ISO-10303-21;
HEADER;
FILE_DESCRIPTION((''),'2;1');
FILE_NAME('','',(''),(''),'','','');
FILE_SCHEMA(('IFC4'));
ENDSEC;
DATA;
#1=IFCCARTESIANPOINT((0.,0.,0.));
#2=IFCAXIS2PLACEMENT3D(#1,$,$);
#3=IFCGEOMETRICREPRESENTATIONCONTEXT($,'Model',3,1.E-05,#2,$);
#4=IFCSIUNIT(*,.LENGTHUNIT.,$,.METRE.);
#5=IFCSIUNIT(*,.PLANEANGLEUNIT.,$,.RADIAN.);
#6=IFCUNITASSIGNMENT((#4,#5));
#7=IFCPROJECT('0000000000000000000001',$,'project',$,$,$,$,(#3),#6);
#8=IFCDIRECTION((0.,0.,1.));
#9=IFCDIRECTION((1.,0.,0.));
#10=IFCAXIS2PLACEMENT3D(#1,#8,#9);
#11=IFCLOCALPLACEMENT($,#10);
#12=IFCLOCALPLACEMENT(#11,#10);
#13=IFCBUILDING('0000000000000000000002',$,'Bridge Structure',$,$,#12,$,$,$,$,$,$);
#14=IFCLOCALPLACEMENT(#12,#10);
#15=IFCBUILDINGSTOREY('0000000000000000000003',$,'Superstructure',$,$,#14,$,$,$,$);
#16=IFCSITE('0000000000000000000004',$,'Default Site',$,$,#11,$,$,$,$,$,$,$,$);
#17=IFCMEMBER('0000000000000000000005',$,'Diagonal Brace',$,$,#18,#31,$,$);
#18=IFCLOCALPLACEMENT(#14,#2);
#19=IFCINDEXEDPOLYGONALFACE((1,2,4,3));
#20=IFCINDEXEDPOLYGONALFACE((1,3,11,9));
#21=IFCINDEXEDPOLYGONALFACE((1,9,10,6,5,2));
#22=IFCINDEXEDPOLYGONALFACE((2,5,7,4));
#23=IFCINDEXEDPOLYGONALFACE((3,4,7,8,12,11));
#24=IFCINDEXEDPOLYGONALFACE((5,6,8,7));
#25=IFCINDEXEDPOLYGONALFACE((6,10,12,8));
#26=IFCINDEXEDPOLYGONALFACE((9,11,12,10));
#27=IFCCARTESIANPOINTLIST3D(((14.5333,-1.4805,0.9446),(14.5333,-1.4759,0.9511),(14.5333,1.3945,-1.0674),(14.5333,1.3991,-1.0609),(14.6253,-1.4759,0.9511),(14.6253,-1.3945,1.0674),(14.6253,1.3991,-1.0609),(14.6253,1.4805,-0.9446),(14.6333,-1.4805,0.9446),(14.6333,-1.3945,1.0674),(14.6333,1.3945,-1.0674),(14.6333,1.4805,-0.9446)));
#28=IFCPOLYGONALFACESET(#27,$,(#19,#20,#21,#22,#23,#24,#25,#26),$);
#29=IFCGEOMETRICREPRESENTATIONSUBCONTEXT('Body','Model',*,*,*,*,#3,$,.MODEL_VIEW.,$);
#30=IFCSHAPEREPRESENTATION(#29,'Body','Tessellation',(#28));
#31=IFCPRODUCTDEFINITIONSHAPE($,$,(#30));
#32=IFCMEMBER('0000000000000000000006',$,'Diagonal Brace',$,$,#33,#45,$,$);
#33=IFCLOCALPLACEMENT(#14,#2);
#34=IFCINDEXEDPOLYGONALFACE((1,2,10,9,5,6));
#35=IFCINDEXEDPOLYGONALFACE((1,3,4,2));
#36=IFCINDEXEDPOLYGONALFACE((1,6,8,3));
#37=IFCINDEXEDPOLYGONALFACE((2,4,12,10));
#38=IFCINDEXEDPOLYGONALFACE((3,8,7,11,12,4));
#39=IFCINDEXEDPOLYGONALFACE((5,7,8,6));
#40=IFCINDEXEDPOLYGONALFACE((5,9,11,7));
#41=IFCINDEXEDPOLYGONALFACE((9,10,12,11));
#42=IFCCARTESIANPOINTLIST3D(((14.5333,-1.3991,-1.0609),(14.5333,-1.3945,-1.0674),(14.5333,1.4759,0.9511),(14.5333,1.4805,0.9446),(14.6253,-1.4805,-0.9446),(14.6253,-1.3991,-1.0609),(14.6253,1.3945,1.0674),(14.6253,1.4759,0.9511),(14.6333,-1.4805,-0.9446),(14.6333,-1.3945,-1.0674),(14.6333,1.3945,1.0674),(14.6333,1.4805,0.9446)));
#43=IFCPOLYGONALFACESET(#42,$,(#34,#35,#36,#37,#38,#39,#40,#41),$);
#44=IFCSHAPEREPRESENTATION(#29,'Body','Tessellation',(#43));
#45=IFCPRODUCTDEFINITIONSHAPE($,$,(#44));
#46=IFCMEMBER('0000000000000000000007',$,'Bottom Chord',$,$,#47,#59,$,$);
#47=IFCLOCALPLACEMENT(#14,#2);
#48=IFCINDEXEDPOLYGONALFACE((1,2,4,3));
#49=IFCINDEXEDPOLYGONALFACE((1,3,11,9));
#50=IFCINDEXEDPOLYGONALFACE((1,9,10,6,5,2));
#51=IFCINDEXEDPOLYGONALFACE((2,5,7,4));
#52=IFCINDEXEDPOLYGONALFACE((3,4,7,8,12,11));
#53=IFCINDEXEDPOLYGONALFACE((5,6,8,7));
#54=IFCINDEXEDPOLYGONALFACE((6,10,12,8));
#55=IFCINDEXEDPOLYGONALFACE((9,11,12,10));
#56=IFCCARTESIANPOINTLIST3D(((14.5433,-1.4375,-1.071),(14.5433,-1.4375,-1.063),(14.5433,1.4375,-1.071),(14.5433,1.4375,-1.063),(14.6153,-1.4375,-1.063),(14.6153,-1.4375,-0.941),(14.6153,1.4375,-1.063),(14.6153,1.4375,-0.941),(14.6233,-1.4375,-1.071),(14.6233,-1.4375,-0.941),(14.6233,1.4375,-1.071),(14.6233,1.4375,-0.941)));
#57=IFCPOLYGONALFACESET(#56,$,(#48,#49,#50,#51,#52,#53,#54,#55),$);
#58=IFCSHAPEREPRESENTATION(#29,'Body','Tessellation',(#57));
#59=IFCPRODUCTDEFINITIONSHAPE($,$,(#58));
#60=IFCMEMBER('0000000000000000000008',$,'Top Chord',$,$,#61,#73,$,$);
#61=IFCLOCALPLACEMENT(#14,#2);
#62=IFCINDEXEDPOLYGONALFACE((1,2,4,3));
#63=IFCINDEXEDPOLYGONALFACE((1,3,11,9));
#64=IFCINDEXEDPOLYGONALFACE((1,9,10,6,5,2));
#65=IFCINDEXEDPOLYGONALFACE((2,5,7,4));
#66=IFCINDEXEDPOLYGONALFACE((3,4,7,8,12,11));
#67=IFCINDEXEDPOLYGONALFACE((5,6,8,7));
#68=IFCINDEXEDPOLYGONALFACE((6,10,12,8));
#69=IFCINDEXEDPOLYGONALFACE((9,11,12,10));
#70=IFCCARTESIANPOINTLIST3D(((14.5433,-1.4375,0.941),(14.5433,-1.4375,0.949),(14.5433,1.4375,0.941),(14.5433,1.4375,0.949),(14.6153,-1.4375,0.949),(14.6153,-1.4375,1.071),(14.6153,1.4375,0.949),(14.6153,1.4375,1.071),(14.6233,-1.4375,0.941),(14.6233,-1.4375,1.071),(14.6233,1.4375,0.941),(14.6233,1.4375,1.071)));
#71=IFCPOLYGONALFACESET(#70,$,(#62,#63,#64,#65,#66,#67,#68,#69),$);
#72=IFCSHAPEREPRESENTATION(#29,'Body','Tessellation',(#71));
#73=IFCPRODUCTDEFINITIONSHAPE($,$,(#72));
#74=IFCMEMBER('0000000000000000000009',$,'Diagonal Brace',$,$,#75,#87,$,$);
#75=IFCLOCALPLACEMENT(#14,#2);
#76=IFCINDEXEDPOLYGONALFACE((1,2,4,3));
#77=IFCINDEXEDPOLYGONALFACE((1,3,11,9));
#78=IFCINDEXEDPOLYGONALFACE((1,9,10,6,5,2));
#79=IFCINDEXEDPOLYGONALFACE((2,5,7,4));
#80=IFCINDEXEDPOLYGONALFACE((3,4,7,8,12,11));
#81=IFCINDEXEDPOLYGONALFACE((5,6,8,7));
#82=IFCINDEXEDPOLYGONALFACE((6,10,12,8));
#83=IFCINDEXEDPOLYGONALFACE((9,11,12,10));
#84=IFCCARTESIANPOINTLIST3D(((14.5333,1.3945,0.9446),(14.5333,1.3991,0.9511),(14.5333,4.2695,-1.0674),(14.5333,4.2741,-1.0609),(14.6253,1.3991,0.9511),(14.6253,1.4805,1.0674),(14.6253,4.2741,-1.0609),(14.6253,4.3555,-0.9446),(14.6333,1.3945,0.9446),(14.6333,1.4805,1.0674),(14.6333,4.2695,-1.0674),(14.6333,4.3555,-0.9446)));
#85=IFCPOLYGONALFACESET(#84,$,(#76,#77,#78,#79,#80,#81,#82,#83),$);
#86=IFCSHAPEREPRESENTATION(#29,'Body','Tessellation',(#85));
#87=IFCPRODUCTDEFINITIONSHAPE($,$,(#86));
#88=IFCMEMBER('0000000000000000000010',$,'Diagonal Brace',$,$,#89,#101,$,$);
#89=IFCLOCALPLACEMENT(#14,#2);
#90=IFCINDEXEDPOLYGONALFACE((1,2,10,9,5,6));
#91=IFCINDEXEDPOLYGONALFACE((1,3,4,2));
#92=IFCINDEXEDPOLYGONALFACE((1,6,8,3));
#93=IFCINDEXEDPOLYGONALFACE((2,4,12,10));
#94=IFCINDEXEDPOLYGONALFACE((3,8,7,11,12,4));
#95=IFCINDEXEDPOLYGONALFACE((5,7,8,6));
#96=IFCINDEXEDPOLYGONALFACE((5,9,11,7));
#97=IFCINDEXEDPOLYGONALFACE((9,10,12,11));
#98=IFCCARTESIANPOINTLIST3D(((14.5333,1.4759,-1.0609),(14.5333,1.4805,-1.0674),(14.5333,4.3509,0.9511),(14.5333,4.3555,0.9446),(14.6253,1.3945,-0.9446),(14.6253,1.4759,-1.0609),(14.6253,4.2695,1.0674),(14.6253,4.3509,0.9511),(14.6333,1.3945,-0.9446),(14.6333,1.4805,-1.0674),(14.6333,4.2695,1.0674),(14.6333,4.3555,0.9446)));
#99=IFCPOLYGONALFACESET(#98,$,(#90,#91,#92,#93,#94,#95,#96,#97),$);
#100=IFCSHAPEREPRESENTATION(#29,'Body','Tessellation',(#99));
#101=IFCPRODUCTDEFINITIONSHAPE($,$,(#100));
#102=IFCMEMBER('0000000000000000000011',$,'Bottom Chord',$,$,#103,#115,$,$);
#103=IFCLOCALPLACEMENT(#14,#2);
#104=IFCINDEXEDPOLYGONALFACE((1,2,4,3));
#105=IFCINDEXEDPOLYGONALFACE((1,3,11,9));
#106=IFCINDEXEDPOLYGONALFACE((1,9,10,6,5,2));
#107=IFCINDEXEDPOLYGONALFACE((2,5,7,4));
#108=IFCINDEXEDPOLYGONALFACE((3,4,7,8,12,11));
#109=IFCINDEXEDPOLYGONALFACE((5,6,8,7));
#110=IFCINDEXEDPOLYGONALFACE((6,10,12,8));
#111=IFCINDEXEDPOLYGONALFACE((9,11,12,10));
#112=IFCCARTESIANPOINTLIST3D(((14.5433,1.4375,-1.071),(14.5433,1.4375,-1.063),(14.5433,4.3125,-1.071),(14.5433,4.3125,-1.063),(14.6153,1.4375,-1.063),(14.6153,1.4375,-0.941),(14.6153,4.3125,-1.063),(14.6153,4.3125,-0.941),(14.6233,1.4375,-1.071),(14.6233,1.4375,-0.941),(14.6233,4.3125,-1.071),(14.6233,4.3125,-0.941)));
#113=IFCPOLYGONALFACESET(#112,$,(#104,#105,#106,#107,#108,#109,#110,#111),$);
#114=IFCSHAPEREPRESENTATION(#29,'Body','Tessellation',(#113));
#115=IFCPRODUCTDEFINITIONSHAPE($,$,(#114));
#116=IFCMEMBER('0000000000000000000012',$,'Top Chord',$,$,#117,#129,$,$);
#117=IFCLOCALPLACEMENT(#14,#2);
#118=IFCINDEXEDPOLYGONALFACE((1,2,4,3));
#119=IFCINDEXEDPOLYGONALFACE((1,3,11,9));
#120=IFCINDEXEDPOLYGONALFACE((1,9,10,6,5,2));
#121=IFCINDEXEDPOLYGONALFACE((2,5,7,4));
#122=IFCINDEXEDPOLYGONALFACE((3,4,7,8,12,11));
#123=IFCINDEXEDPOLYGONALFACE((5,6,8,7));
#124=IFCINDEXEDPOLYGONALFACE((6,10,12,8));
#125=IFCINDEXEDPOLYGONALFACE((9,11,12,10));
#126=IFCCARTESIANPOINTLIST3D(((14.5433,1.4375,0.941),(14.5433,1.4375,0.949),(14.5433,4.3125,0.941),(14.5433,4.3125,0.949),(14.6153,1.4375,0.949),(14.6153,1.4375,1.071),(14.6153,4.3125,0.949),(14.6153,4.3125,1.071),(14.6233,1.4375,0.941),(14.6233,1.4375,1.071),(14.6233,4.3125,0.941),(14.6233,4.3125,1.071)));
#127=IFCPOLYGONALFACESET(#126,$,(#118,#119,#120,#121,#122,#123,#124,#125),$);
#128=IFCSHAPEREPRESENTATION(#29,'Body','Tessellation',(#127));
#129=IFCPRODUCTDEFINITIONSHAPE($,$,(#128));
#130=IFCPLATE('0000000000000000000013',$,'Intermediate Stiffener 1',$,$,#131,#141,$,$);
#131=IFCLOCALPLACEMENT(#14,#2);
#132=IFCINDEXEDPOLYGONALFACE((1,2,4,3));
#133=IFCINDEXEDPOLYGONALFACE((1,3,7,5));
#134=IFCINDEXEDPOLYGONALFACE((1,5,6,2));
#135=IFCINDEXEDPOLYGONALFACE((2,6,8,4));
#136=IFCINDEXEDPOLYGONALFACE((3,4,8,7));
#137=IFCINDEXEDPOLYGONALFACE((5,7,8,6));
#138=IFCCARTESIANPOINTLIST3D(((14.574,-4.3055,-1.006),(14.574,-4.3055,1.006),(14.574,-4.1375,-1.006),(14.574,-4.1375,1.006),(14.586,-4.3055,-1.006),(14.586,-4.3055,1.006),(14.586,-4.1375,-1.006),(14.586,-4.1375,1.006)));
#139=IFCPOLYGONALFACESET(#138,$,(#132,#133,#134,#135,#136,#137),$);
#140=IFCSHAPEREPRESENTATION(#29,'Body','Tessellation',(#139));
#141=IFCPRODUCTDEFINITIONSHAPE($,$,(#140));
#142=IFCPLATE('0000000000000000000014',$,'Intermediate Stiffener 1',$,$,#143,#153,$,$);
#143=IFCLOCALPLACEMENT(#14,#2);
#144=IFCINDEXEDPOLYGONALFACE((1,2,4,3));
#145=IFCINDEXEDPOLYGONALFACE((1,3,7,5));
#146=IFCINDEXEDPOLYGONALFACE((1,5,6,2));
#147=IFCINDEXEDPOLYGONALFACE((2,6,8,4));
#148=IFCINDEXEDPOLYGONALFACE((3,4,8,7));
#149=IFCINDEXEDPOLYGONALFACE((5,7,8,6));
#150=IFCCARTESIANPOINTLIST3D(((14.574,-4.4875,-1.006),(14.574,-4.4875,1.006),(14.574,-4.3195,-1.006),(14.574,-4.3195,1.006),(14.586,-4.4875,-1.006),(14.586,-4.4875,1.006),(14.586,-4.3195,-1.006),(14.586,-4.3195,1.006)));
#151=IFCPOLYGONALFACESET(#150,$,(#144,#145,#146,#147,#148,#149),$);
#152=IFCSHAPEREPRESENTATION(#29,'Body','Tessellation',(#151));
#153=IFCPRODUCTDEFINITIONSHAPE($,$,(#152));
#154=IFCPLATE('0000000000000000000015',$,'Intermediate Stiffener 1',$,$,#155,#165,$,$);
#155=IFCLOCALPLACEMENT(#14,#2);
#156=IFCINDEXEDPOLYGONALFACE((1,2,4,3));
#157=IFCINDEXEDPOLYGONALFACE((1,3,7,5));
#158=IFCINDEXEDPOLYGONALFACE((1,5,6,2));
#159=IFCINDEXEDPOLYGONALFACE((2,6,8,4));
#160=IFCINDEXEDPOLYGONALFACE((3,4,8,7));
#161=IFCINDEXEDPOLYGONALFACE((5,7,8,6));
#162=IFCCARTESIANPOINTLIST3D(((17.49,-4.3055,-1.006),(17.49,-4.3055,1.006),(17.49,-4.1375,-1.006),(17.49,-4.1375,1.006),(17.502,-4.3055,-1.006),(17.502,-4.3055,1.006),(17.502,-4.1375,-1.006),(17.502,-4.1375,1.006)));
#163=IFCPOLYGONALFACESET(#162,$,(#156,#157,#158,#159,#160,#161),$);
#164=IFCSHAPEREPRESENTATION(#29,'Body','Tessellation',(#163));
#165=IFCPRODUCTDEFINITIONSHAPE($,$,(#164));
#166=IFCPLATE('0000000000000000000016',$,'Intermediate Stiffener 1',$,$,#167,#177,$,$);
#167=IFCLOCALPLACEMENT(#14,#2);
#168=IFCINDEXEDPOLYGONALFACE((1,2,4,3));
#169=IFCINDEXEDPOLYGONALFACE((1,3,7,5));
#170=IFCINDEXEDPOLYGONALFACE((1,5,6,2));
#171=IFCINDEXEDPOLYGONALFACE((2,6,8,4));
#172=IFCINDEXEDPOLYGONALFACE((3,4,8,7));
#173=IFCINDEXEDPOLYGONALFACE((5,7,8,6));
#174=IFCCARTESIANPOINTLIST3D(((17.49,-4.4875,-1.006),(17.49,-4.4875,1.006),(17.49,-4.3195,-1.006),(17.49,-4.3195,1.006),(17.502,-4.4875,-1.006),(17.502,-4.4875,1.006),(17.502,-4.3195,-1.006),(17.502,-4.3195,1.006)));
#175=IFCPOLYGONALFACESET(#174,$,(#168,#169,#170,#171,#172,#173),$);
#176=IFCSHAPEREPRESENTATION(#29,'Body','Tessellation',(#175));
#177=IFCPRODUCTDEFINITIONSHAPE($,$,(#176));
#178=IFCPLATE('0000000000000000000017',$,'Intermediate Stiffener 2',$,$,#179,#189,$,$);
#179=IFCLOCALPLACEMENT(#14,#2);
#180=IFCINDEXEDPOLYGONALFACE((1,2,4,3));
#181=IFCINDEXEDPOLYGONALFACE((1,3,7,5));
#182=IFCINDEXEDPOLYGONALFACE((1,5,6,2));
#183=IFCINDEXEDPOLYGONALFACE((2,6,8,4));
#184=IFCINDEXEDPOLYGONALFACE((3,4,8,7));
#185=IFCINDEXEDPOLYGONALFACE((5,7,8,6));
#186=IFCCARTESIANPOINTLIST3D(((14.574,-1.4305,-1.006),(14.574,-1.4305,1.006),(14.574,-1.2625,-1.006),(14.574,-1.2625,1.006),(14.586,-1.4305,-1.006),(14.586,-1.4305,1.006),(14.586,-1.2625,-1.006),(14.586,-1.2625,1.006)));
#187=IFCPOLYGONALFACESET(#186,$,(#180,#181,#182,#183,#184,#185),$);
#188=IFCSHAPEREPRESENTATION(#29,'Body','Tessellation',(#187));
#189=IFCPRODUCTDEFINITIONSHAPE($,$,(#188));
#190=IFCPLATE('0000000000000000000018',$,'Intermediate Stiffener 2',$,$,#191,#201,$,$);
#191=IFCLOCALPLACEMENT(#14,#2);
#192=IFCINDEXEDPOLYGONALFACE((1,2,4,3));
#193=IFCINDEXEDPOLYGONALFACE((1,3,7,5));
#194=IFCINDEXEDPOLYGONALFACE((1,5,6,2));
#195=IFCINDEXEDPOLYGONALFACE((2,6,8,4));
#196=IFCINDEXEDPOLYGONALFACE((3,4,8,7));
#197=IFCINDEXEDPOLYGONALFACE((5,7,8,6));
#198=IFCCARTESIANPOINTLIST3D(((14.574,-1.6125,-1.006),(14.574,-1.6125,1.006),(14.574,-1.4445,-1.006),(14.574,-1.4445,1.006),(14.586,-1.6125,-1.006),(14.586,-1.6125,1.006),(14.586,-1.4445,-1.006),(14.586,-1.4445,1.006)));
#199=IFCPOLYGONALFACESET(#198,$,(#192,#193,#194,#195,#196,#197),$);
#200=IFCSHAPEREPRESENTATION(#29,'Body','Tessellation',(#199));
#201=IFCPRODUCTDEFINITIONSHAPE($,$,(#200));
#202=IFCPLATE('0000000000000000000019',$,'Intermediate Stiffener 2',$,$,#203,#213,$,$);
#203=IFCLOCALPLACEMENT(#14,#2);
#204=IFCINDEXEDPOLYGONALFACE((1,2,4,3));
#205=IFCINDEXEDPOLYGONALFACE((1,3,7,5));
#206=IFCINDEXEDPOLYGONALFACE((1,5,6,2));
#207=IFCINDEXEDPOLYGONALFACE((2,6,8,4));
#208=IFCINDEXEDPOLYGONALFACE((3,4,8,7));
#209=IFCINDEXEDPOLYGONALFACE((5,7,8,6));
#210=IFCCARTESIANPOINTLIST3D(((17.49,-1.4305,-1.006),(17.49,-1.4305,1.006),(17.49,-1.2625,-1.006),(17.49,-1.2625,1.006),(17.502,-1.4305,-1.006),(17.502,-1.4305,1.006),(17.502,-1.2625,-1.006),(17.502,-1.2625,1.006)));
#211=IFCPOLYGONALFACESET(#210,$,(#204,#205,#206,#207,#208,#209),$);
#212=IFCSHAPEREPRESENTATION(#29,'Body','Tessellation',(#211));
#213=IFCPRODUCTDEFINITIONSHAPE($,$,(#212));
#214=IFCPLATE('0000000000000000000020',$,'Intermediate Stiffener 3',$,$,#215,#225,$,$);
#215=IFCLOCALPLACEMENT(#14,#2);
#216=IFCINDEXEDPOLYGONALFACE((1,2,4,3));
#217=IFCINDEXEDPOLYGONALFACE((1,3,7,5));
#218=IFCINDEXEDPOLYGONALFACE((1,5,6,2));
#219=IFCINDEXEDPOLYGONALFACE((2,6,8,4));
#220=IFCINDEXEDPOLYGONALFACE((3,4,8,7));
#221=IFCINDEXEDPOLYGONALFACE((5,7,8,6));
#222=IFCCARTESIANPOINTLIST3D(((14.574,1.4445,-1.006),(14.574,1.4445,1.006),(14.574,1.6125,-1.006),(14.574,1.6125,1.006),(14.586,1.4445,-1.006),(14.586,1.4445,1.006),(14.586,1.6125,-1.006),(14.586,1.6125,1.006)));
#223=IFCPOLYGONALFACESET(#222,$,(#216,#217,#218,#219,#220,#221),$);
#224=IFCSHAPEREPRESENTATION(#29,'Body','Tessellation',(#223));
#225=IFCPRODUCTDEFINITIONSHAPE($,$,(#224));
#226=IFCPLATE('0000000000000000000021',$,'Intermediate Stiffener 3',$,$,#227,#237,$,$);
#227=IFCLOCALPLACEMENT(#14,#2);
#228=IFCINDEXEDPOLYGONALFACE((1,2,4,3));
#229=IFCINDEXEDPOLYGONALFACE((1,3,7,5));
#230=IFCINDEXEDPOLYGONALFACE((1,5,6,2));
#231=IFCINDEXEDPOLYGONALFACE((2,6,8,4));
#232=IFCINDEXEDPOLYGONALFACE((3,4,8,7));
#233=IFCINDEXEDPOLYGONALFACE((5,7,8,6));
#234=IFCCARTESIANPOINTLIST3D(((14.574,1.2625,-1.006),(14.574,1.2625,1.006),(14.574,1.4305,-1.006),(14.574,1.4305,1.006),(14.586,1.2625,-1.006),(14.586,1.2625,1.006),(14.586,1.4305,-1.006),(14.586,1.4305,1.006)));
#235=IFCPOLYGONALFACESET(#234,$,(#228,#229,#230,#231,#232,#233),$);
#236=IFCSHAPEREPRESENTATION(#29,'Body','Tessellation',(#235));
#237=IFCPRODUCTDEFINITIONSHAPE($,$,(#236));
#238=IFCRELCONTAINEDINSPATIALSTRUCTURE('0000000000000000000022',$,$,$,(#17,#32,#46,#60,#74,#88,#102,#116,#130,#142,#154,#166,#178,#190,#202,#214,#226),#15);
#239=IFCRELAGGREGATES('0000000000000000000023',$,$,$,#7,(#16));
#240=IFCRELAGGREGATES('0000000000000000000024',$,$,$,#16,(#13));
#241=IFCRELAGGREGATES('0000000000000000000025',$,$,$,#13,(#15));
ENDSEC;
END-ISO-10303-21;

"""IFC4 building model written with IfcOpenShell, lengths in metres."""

from ifc_helpers import new_model, si_unit, frame, origin, origin_with_axes, origin_2d_with_axis, place, context, subcontext, project, spatial, rectangle, l_section, extrude, element, save


model = new_model("IFC4")

# Units and contexts
model_context = context("Model", 3, precision=1e-05, world=origin())
body_context = subcontext(model_context, "Body", "Model", "MODEL_VIEW")
ifc_project = project(units=[si_unit("LENGTHUNIT", "METRE"), si_unit("PLANEANGLEUNIT", "RADIAN")], contexts=[model_context])

# Site, building, storey
site_placement = place(None, origin_with_axes())
site = spatial("IfcSite", under=ifc_project, at=site_placement, Name="Default Site")
building_placement = place(site_placement, origin_with_axes())
building = spatial("IfcBuilding", under=site, at=building_placement, Name="Bridge Structure")
storey_placement = place(building_placement, origin_with_axes())
storey = spatial("IfcBuildingStorey", under=building, at=storey_placement, Name="Superstructure")

# Members
for number, where, z_axis, x_axis, name in (
    (1, (14.5833, -1.4375, 1.006), (0.0, 0.819299, -0.573367), (-1.0, 0.0, 0.0), "Diagonal Brace"),
    (2, (14.5833, -1.4375, -1.006), (0.0, 0.819299, 0.573367), (-1.0, 0.0, 0.0), "Diagonal Brace"),
):
    element("IfcMember", number, at=place(storey_placement, frame(where, z_axis=z_axis, x_axis=x_axis)), inside=storey, Name=name, context=body_context, shape_type="SweptSolid", body=[
        extrude(l_section(Depth=0.15, Width=0.1, Thickness=0.008, at=origin_2d_with_axis()), origin_with_axes(), (0.0, 0.0, 1.0), 3.5091),
    ])
for number, where, z_axis, x_axis, name in (
    (3, (14.5833, -1.4375, -1.006), (0.0, 1.0, 0.0), (-1.0, 0.0, 0.0), "Bottom Chord"),
    (4, (14.5833, -1.4375, 1.006), (0.0, 1.0, 0.0), (-1.0, 0.0, 0.0), "Top Chord"),
):
    element("IfcMember", number, at=place(storey_placement, frame(where, z_axis=z_axis, x_axis=x_axis)), inside=storey, Name=name, context=body_context, shape_type="SweptSolid", body=[
        extrude(l_section(Depth=0.13, Width=0.08, Thickness=0.008, at=origin_2d_with_axis()), origin_with_axes(), (0.0, 0.0, 1.0), 2.875),
    ])
for number, where, z_axis, x_axis, name in (
    (5, (14.5833, 1.4375, 1.006), (0.0, 0.819299, -0.573367), (-1.0, 0.0, 0.0), "Diagonal Brace"),
    (6, (14.5833, 1.4375, -1.006), (0.0, 0.819299, 0.573367), (-1.0, 0.0, 0.0), "Diagonal Brace"),
):
    element("IfcMember", number, at=place(storey_placement, frame(where, z_axis=z_axis, x_axis=x_axis)), inside=storey, Name=name, context=body_context, shape_type="SweptSolid", body=[
        extrude(l_section(Depth=0.15, Width=0.1, Thickness=0.008, at=origin_2d_with_axis()), origin_with_axes(), (0.0, 0.0, 1.0), 3.5091),
    ])
for number, where, z_axis, x_axis, name in (
    (7, (14.5833, 1.4375, -1.006), (0.0, 1.0, 0.0), (-1.0, 0.0, 0.0), "Bottom Chord"),
    (8, (14.5833, 1.4375, 1.006), (0.0, 1.0, 0.0), (-1.0, 0.0, 0.0), "Top Chord"),
):
    element("IfcMember", number, at=place(storey_placement, frame(where, z_axis=z_axis, x_axis=x_axis)), inside=storey, Name=name, context=body_context, shape_type="SweptSolid", body=[
        extrude(l_section(Depth=0.13, Width=0.08, Thickness=0.008, at=origin_2d_with_axis()), origin_with_axes(), (0.0, 0.0, 1.0), 2.875),
    ])

# Plates
for number, where, z_axis, x_axis, name in (
    (9, (14.58, -4.2215, -1.006), (0.0, 0.0, 1.0), (1.0, 0.0, 0.0), "Intermediate Stiffener 1"),
    (10, (14.58, -4.4035, -1.006), (0.0, 0.0, 1.0), (1.0, 0.0, 0.0), "Intermediate Stiffener 1"),
    (11, (17.496, -4.2215, -1.006), (0.0, 0.0, 1.0), (1.0, 0.0, 0.0), "Intermediate Stiffener 1"),
    (12, (17.496, -4.4035, -1.006), (0.0, 0.0, 1.0), (1.0, 0.0, 0.0), "Intermediate Stiffener 1"),
    (13, (14.58, -1.3465, -1.006), (0.0, 0.0, 1.0), (1.0, 0.0, 0.0), "Intermediate Stiffener 2"),
    (14, (14.58, -1.5285, -1.006), (0.0, 0.0, 1.0), (1.0, 0.0, 0.0), "Intermediate Stiffener 2"),
    (15, (17.496, -1.3465, -1.006), (0.0, 0.0, 1.0), (1.0, 0.0, 0.0), "Intermediate Stiffener 2"),
    (16, (14.58, 1.5285, -1.006), (0.0, 0.0, 1.0), (1.0, 0.0, 0.0), "Intermediate Stiffener 3"),
    (17, (14.58, 1.3465, -1.006), (0.0, 0.0, 1.0), (1.0, 0.0, 0.0), "Intermediate Stiffener 3"),
):
    element("IfcPlate", number, at=place(storey_placement, frame(where, z_axis=z_axis, x_axis=x_axis)), inside=storey, Name=name, context=body_context, shape_type="SweptSolid", body=[
        extrude(rectangle(XDim=0.012, YDim=0.168, at=origin_2d_with_axis()), origin_with_axes(), (0.0, 0.0, 1.0), 2.012),
    ])

save(model, "model.ifc")
